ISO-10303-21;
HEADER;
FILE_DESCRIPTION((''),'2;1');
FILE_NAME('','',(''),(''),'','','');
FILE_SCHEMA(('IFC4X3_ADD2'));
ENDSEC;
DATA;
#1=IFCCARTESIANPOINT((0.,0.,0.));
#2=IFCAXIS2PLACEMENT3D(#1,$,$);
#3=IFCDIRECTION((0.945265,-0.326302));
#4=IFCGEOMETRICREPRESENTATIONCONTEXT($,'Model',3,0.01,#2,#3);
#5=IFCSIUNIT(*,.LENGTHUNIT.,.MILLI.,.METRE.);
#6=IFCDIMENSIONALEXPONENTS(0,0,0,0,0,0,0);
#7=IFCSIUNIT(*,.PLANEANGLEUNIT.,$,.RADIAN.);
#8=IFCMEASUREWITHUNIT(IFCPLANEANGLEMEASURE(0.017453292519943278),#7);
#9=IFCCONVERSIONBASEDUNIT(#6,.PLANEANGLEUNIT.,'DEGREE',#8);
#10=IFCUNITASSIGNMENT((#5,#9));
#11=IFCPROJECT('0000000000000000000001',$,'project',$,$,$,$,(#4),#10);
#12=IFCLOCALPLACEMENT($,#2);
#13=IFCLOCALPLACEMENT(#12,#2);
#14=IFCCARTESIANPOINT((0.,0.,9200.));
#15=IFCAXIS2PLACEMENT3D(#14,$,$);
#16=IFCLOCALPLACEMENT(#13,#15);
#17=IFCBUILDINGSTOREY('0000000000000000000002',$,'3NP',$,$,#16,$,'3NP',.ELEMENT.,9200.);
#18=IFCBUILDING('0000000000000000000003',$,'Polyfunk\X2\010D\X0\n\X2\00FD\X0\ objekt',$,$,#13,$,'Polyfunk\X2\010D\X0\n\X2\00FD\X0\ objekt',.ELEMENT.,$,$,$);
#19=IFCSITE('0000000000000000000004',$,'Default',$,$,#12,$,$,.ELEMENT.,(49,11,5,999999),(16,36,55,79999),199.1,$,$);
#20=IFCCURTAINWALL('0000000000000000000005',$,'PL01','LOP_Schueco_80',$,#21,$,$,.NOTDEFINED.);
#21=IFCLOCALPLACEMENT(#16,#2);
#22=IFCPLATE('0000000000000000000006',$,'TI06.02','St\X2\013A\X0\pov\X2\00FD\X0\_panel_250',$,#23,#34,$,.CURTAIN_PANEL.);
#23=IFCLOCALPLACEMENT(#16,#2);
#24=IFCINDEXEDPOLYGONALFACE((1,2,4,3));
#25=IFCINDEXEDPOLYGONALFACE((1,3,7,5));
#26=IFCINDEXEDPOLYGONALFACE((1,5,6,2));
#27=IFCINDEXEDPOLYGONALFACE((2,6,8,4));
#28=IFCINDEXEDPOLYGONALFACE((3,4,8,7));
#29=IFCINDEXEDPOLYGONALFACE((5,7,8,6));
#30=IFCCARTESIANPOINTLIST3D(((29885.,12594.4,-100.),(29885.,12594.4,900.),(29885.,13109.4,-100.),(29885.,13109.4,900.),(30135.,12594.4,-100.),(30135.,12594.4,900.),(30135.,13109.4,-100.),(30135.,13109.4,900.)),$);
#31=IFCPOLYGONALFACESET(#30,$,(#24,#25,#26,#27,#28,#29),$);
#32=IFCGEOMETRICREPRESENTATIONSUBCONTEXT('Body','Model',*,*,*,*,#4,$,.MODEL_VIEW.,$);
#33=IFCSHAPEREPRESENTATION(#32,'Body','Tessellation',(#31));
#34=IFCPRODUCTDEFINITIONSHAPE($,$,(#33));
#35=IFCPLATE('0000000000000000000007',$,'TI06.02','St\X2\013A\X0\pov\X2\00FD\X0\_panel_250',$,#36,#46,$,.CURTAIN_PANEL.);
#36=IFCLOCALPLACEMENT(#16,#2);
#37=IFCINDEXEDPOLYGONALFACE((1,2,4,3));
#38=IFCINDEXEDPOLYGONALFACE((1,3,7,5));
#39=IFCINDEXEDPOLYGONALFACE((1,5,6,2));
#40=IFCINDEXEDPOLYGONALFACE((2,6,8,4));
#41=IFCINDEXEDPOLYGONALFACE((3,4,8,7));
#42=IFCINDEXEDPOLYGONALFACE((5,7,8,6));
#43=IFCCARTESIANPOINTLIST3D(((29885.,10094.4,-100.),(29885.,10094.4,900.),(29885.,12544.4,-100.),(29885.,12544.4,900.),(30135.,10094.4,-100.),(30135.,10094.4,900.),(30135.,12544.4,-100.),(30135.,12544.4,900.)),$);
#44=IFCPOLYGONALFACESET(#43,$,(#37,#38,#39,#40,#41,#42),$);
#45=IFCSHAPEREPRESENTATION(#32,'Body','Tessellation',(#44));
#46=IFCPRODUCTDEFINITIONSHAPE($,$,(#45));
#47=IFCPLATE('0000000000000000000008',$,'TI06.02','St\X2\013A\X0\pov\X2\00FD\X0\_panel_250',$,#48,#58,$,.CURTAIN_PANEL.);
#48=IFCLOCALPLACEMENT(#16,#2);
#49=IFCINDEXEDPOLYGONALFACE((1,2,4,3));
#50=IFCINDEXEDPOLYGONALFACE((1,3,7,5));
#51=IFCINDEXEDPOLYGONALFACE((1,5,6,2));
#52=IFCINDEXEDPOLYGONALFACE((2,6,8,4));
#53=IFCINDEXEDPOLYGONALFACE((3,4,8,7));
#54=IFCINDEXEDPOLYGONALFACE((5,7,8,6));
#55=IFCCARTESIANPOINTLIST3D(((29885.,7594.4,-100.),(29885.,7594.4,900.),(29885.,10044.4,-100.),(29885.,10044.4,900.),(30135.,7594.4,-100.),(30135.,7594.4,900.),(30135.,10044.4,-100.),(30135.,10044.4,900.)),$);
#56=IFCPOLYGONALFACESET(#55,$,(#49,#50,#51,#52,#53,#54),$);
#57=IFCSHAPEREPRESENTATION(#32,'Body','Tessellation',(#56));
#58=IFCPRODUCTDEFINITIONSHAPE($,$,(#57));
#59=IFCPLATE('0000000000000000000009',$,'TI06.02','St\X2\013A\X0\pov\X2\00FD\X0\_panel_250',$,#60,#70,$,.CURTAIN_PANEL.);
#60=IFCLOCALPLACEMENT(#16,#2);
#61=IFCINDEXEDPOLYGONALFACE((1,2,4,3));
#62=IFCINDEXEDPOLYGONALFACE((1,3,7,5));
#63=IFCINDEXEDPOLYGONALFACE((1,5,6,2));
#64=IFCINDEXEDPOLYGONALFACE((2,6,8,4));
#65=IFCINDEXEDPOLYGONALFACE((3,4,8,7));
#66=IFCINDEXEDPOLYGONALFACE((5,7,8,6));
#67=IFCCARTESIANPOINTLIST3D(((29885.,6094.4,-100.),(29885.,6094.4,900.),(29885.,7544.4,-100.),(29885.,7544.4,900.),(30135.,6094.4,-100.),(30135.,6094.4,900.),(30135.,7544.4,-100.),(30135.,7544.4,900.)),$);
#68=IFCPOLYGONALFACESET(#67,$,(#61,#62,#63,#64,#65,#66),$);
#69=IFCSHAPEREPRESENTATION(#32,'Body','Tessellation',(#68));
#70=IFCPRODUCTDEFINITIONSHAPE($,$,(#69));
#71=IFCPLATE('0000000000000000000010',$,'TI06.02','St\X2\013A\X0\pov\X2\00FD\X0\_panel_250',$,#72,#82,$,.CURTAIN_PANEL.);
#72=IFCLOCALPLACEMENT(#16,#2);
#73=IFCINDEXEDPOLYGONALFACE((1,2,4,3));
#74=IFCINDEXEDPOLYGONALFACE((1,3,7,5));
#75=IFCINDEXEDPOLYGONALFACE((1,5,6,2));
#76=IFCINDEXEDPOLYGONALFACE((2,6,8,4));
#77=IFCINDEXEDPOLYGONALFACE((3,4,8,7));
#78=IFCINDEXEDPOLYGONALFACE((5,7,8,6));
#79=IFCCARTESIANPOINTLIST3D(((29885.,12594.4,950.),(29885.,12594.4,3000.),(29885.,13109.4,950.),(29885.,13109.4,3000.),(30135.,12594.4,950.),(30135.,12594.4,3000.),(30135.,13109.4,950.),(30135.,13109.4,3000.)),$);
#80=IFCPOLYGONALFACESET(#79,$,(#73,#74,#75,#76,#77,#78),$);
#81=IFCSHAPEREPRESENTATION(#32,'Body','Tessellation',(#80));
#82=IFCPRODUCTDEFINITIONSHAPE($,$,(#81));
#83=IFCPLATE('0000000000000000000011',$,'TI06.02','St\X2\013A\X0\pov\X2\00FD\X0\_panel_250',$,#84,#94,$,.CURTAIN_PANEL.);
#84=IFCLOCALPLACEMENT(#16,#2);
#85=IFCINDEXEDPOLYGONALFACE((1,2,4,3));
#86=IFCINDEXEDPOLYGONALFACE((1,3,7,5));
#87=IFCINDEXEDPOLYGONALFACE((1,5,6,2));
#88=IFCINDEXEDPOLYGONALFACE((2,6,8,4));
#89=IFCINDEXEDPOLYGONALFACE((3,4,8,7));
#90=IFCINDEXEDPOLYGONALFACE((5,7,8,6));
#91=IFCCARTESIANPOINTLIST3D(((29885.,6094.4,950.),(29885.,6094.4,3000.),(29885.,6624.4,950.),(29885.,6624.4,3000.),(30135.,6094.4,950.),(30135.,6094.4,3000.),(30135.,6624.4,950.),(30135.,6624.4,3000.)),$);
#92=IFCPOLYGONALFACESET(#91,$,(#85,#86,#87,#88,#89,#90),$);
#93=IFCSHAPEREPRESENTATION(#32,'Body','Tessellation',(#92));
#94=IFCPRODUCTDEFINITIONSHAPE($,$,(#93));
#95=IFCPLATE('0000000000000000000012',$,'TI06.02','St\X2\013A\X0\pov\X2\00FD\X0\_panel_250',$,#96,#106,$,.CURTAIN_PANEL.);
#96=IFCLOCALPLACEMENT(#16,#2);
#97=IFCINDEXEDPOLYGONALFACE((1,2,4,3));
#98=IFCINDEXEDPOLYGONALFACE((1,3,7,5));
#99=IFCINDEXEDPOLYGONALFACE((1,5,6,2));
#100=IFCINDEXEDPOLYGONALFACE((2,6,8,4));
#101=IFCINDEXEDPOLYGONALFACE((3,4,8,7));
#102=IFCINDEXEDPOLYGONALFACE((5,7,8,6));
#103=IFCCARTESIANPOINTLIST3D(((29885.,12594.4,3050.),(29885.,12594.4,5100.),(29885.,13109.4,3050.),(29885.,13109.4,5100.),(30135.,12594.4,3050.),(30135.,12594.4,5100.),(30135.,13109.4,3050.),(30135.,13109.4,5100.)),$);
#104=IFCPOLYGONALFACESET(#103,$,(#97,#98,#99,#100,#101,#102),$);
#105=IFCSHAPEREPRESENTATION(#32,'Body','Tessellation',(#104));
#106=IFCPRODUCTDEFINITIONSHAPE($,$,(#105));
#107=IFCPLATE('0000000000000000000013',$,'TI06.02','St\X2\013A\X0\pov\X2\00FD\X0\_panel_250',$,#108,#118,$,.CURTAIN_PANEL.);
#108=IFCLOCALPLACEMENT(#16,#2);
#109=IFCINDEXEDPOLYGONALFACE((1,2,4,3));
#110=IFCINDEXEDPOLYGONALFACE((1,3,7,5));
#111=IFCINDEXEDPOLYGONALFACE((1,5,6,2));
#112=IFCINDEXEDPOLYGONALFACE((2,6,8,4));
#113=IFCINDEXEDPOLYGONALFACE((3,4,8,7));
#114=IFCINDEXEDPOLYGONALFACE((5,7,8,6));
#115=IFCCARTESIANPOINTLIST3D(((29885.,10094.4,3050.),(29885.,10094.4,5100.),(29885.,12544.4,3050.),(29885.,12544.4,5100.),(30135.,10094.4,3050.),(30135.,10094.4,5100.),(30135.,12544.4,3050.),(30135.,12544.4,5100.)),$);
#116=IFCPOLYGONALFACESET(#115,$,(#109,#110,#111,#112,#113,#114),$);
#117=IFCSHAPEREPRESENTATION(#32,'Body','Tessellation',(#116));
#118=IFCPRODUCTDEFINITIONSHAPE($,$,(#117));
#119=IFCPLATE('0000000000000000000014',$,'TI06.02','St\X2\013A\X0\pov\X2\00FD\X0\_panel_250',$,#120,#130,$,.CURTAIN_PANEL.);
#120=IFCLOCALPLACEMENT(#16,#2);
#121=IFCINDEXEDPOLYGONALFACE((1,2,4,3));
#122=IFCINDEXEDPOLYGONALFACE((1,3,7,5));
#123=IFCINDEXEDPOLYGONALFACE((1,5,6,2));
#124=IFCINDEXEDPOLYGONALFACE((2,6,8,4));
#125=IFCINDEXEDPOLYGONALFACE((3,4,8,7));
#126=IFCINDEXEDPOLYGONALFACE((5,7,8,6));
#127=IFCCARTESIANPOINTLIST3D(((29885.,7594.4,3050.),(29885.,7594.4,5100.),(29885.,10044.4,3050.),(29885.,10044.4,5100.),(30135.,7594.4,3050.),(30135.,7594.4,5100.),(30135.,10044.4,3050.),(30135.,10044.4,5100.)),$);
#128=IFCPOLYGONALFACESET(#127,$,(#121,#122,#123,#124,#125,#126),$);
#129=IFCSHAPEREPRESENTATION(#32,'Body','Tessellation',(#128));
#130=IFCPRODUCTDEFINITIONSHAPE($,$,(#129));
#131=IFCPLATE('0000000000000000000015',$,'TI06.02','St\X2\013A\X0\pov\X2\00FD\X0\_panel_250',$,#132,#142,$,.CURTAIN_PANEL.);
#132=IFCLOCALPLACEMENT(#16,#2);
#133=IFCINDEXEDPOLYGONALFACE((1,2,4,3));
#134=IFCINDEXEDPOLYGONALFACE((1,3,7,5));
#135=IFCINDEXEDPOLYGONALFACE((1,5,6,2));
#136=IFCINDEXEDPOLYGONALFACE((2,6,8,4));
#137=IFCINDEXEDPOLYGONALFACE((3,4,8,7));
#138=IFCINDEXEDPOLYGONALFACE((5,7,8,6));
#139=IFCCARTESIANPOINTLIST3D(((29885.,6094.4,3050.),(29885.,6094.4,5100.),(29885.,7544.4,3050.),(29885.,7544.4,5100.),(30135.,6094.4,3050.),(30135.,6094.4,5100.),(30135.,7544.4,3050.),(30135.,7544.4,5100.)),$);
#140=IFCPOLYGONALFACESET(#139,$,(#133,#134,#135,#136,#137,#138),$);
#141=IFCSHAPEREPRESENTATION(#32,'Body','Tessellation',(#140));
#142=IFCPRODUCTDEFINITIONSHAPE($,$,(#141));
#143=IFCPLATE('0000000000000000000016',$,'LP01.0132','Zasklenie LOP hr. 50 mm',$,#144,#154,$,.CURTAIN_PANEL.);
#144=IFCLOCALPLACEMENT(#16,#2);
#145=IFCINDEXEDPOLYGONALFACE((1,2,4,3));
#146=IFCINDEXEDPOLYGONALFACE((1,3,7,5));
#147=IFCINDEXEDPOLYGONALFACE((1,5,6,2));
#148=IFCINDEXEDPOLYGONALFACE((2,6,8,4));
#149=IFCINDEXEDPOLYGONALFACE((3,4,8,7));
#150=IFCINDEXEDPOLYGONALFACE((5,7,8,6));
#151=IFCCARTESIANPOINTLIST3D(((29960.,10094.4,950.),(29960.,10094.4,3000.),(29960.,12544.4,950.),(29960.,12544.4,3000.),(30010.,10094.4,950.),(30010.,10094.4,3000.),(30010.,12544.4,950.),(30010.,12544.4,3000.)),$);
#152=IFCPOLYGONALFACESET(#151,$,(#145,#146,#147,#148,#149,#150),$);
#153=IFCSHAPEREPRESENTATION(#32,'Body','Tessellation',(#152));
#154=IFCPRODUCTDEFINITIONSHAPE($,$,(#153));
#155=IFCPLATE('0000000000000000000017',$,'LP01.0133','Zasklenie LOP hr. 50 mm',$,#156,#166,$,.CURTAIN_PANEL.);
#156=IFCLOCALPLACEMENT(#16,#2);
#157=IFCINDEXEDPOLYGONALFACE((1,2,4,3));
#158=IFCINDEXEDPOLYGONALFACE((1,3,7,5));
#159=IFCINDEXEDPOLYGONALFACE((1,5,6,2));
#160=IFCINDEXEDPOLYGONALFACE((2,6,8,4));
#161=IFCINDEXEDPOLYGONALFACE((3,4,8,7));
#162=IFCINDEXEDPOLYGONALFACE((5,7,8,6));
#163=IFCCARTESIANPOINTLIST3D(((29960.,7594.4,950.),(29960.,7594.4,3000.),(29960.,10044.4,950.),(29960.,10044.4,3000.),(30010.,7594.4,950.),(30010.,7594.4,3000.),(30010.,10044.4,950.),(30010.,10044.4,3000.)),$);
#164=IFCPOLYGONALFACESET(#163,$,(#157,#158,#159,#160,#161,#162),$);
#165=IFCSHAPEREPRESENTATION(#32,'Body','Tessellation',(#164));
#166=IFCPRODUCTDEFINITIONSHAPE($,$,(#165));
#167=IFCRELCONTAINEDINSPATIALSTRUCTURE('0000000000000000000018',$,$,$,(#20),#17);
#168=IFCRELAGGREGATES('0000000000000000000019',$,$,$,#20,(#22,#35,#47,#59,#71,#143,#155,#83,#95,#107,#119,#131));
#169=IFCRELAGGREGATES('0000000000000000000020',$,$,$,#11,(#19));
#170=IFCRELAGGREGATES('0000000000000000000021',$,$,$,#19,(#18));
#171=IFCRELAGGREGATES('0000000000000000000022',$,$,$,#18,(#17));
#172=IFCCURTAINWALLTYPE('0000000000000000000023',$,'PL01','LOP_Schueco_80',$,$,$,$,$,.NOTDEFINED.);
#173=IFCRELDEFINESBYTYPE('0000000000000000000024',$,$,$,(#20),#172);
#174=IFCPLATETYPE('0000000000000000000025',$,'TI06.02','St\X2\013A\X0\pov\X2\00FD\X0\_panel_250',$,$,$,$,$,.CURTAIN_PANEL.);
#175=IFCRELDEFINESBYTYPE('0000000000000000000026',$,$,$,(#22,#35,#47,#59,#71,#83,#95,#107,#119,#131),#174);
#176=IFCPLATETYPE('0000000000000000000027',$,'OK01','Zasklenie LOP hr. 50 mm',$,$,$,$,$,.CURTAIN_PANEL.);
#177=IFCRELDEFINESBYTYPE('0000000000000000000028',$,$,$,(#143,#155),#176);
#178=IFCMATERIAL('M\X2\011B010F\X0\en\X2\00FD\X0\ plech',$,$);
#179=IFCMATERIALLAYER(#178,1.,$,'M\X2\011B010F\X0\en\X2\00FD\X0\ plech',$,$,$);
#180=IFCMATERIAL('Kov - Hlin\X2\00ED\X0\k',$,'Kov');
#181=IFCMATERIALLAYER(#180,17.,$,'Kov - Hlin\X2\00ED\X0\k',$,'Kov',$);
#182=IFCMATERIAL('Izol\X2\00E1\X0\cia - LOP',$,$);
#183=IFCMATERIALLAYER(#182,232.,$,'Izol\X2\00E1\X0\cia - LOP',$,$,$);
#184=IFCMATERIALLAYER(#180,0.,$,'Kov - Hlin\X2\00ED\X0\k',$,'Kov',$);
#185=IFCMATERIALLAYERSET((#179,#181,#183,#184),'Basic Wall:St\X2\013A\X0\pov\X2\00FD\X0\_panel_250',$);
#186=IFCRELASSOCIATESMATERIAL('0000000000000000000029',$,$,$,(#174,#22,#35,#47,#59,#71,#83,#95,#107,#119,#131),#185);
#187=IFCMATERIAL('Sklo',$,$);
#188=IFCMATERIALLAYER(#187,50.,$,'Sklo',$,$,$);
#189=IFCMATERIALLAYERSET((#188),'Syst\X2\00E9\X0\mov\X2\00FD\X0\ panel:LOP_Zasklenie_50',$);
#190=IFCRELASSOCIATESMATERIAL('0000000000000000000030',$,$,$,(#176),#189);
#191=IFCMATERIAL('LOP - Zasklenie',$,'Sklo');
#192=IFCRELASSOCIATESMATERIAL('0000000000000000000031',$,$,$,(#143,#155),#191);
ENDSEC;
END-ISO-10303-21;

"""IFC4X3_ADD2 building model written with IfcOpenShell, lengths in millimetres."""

from ifc_helpers import new_model, entity, si_unit, converted_unit, direction, frame, frame_2d, origin, origin_2d_with_axis, place, context, subcontext, project, spatial, rectangle, extrude, source, transform, mapped, material, layer, layer_set, layer_usage, type_object, type_shapes, element, aggregate, save


model = new_model("IFC4X3_ADD2")

# Units and contexts
model_context = context("Model", 3, precision=0.01, world=origin(), true_north=direction((0.945265, -0.326302)))
body_context = subcontext(model_context, "Body", "Model", "MODEL_VIEW")
ifc_project = project(units=[si_unit("LENGTHUNIT", "METRE", prefix="MILLI"), converted_unit("PLANEANGLEUNIT", "DEGREE", entity("IfcPlaneAngleMeasure", 0.017453292519943278), si_unit("PLANEANGLEUNIT", "RADIAN"), dimensions=[0, 0, 0, 0, 0, 0, 0])], contexts=[model_context])

# Site, building, storey
site_placement = place(None, origin())
site = spatial("IfcSite", under=ifc_project, at=site_placement, Name="Default", CompositionType="ELEMENT", RefLatitude=(49, 11, 5, 999999), RefLongitude=(16, 36, 55, 79999), RefElevation=199.1)
building_placement = place(site_placement, origin())
building = spatial("IfcBuilding", under=site, at=building_placement, Name="Polyfunkčný objekt", LongName="Polyfunkčný objekt", CompositionType="ELEMENT")
storey_placement = place(building_placement, frame((0.0, 0.0, 9200.0)))
storey = spatial("IfcBuildingStorey", under=building, at=storey_placement, Name="3NP", LongName="3NP", CompositionType="ELEMENT", Elevation=9200.0)

# Shared definitions
curtain_wall_type = type_object("IfcCurtainWallType", Name="PL01", Description="LOP_Schueco_80", PredefinedType="NOTDEFINED")

# Curtain wall, plates
curtain_wall_1_placement = place(storey_placement, frame((0.0, 0.0, -9200.0)))
curtain_wall_1 = element("IfcCurtainWall", 1, at=curtain_wall_1_placement, inside=storey, type_object=curtain_wall_type, Name="PL01", Description="LOP_Schueco_80", PredefinedType="NOTDEFINED")
ifc_material_1 = material(Name="Měďený plech")
ifc_layer_1 = layer(ifc_material_1, 1.0, Name="Měďený plech")
ifc_material_2 = material(Name="Kov - Hliník", Category="Kov")
ifc_layer_2 = layer(ifc_material_2, 17.0, Name="Kov - Hliník", Category="Kov")
ifc_material_3 = material(Name="Izolácia - LOP")
ifc_layer_3 = layer(ifc_material_3, 232.0, Name="Izolácia - LOP")
ifc_layer_4 = layer(ifc_material_2, 0.0, Name="Kov - Hliník", Category="Kov")
ifc_layer_set_1 = layer_set([ifc_layer_1, ifc_layer_2, ifc_layer_3, ifc_layer_4], Name="Basic Wall:Stĺpový_panel_250")
ifc_layer_usage_1 = layer_usage(ifc_layer_set_1, "AXIS2", "POSITIVE", -125.0)
plate_type_1 = type_object("IfcPlateType", Name="TI06.02", Description="Stĺpový_panel_250", PredefinedType="CURTAIN_PANEL", material=ifc_layer_set_1)
plate_1_placement = place(storey_placement, frame((30010.0, 13109.4, -100.0), z_axis=(0.0, 0.0, 1.0), x_axis=(0.0, -1.0, 0.0)))
plate_1 = element("IfcPlate", 2, at=plate_1_placement, type_object=plate_type_1, material=ifc_layer_usage_1, Name="TI06.02", Description="Stĺpový_panel_250", PredefinedType="CURTAIN_PANEL", context=body_context, shape_type="SweptSolid", body=[
    extrude(rectangle(XDim=250.0, YDim=515.0, at=frame_2d((0.0, 0.0), x_axis=(1.0, 0.0))), frame((257.5, 0.0, 0.0), z_axis=(0.0, 0.0, 1.0), x_axis=(0.0, 1.0, 0.0)), (0.0, 0.0, 1.0), 1000.0),
])
ifc_layer_usage_2 = layer_usage(ifc_layer_set_1, "AXIS2", "POSITIVE", -125.0)
plate_2_placement = place(storey_placement, frame((30010.0, 12544.4, -100.0), z_axis=(0.0, 0.0, 1.0), x_axis=(0.0, -1.0, 0.0)))
plate_2 = element("IfcPlate", 3, at=plate_2_placement, type_object=plate_type_1, material=ifc_layer_usage_2, Name="TI06.02", Description="Stĺpový_panel_250", PredefinedType="CURTAIN_PANEL", context=body_context, shape_type="SweptSolid", body=[
    extrude(rectangle(XDim=250.0, YDim=2450.0, at=frame_2d((0.0, 0.0), x_axis=(1.0, 0.0))), frame((1225.0, 0.0, 0.0), z_axis=(0.0, 0.0, 1.0), x_axis=(0.0, 1.0, 0.0)), (0.0, 0.0, 1.0), 1000.0),
])
ifc_layer_usage_3 = layer_usage(ifc_layer_set_1, "AXIS2", "POSITIVE", -125.0)
plate_3_placement = place(storey_placement, frame((30010.0, 10044.4, -100.0), z_axis=(0.0, 0.0, 1.0), x_axis=(0.0, -1.0, 0.0)))
plate_3 = element("IfcPlate", 4, at=plate_3_placement, type_object=plate_type_1, material=ifc_layer_usage_3, Name="TI06.02", Description="Stĺpový_panel_250", PredefinedType="CURTAIN_PANEL", context=body_context, shape_type="SweptSolid", body=[
    extrude(rectangle(XDim=250.0, YDim=2450.0, at=origin_2d_with_axis()), frame((1225.0, 0.0, 0.0), z_axis=(0.0, 0.0, 1.0), x_axis=(0.0, 1.0, 0.0)), (0.0, 0.0, 1.0), 1000.0),
])
ifc_layer_usage_4 = layer_usage(ifc_layer_set_1, "AXIS2", "POSITIVE", -125.0)
plate_4_placement = place(storey_placement, frame((30010.0, 7544.4, -100.0), z_axis=(0.0, 0.0, 1.0), x_axis=(0.0, -1.0, 0.0)))
plate_4 = element("IfcPlate", 5, at=plate_4_placement, type_object=plate_type_1, material=ifc_layer_usage_4, Name="TI06.02", Description="Stĺpový_panel_250", PredefinedType="CURTAIN_PANEL", context=body_context, shape_type="SweptSolid", body=[
    extrude(rectangle(XDim=250.0, YDim=1450.0, at=frame_2d((0.0, 0.0), x_axis=(1.0, 0.0))), frame((725.0, 0.0, 0.0), z_axis=(0.0, 0.0, 1.0), x_axis=(0.0, 1.0, 0.0)), (0.0, 0.0, 1.0), 1000.0),
])
ifc_layer_usage_5 = layer_usage(ifc_layer_set_1, "AXIS2", "POSITIVE", -125.0)
plate_5_placement = place(storey_placement, frame((30010.0, 13109.4, 950.0), z_axis=(0.0, 0.0, 1.0), x_axis=(0.0, -1.0, 0.0)))
plate_5 = element("IfcPlate", 6, at=plate_5_placement, type_object=plate_type_1, material=ifc_layer_usage_5, Name="TI06.02", Description="Stĺpový_panel_250", PredefinedType="CURTAIN_PANEL", context=body_context, shape_type="SweptSolid", body=[
    extrude(rectangle(XDim=250.0, YDim=515.0, at=frame_2d((0.0, 0.0), x_axis=(1.0, 0.0))), frame((257.5, 0.0, 0.0), z_axis=(0.0, 0.0, 1.0), x_axis=(0.0, 1.0, 0.0)), (0.0, 0.0, 1.0), 2050.0),
])
ifc_layer_usage_6 = layer_usage(ifc_layer_set_1, "AXIS2", "POSITIVE", -125.0)
plate_6_placement = place(storey_placement, frame((30010.0, 6624.4, 950.0), z_axis=(0.0, 0.0, 1.0), x_axis=(0.0, -1.0, 0.0)))
plate_6 = element("IfcPlate", 7, at=plate_6_placement, type_object=plate_type_1, material=ifc_layer_usage_6, Name="TI06.02", Description="Stĺpový_panel_250", PredefinedType="CURTAIN_PANEL", context=body_context, shape_type="SweptSolid", body=[
    extrude(rectangle(XDim=250.0, YDim=530.0, at=frame_2d((0.0, 0.0), x_axis=(1.0, 0.0))), frame((265.0, 0.0, 0.0), z_axis=(0.0, 0.0, 1.0), x_axis=(0.0, 1.0, 0.0)), (0.0, 0.0, 1.0), 2050.0),
])
ifc_layer_usage_7 = layer_usage(ifc_layer_set_1, "AXIS2", "POSITIVE", -125.0)
plate_7_placement = place(storey_placement, frame((30010.0, 13109.4, 3050.0), z_axis=(0.0, 0.0, 1.0), x_axis=(0.0, -1.0, 0.0)))
plate_7 = element("IfcPlate", 8, at=plate_7_placement, type_object=plate_type_1, material=ifc_layer_usage_7, Name="TI06.02", Description="Stĺpový_panel_250", PredefinedType="CURTAIN_PANEL", context=body_context, shape_type="SweptSolid", body=[
    extrude(rectangle(XDim=250.0, YDim=515.0, at=frame_2d((0.0, 0.0), x_axis=(1.0, 0.0))), frame((257.5, 0.0, 0.0), z_axis=(0.0, 0.0, 1.0), x_axis=(0.0, 1.0, 0.0)), (0.0, 0.0, 1.0), 2050.0),
])
ifc_layer_usage_8 = layer_usage(ifc_layer_set_1, "AXIS2", "POSITIVE", -125.0)
plate_8_placement = place(storey_placement, frame((30010.0, 12544.4, 3050.0), z_axis=(0.0, 0.0, 1.0), x_axis=(0.0, -1.0, 0.0)))
plate_8 = element("IfcPlate", 9, at=plate_8_placement, type_object=plate_type_1, material=ifc_layer_usage_8, Name="TI06.02", Description="Stĺpový_panel_250", PredefinedType="CURTAIN_PANEL", context=body_context, shape_type="SweptSolid", body=[
    extrude(rectangle(XDim=250.0, YDim=2450.0, at=frame_2d((0.0, 0.0), x_axis=(1.0, 0.0))), frame((1225.0, 0.0, 0.0), z_axis=(0.0, 0.0, 1.0), x_axis=(0.0, 1.0, 0.0)), (0.0, 0.0, 1.0), 2050.0),
])
ifc_layer_usage_9 = layer_usage(ifc_layer_set_1, "AXIS2", "POSITIVE", -125.0)
plate_9_placement = place(storey_placement, frame((30010.0, 10044.4, 3050.0), z_axis=(0.0, 0.0, 1.0), x_axis=(0.0, -1.0, 0.0)))
plate_9 = element("IfcPlate", 10, at=plate_9_placement, type_object=plate_type_1, material=ifc_layer_usage_9, Name="TI06.02", Description="Stĺpový_panel_250", PredefinedType="CURTAIN_PANEL", context=body_context, shape_type="SweptSolid", body=[
    extrude(rectangle(XDim=250.0, YDim=2450.0, at=frame_2d((0.0, 0.0), x_axis=(1.0, 0.0))), frame((1225.0, 0.0, 0.0), z_axis=(0.0, 0.0, 1.0), x_axis=(0.0, 1.0, 0.0)), (0.0, 0.0, 1.0), 2050.0),
])
ifc_layer_usage_10 = layer_usage(ifc_layer_set_1, "AXIS2", "POSITIVE", -125.0)
plate_10_placement = place(storey_placement, frame((30010.0, 7544.4, 3050.0), z_axis=(0.0, 0.0, 1.0), x_axis=(0.0, -1.0, 0.0)))
plate_10 = element("IfcPlate", 11, at=plate_10_placement, type_object=plate_type_1, material=ifc_layer_usage_10, Name="TI06.02", Description="Stĺpový_panel_250", PredefinedType="CURTAIN_PANEL", context=body_context, shape_type="SweptSolid", body=[
    extrude(rectangle(XDim=250.0, YDim=1450.0, at=frame_2d((0.0, 0.0), x_axis=(1.0, 0.0))), frame((725.0, 0.0, 0.0), z_axis=(0.0, 0.0, 1.0), x_axis=(0.0, 1.0, 0.0)), (0.0, 0.0, 1.0), 2050.0),
])
ifc_material_4 = material(Name="LOP - Zasklenie", Category="Sklo")
ifc_material_5 = material(Name="Sklo")
ifc_layer_5 = layer(ifc_material_5, 50.0, Name="Sklo")
ifc_layer_set_2 = layer_set([ifc_layer_5], Name="Systémový panel:LOP_Zasklenie_50")
plate_type_2 = type_object("IfcPlateType", Name="OK01", Description="Zasklenie LOP hr. 50 mm", PredefinedType="CURTAIN_PANEL", material=ifc_layer_set_2)
shared_shape_1 = source(origin(), body_context, "Body", "SweptSolid", [
    extrude(rectangle(XDim=50.0, YDim=2450.0, at=origin_2d_with_axis()), frame((0.0, -25.0, 0.0), z_axis=(0.0, 0.0, 1.0), x_axis=(0.0, 1.0, 0.0)), (0.0, 0.0, 1.0), 2050.0),
])
type_shapes(plate_type_2, [shared_shape_1])
plate_11_placement = place(curtain_wall_1_placement, frame((30010.0, 11319.4, 10150.0), z_axis=(0.0, 0.0, 1.0), x_axis=(0.0, -1.0, 0.0)))
plate_11 = element("IfcPlate", 12, at=plate_11_placement, type_object=plate_type_2, material=ifc_material_4, Name="LP01.0132", Description="Zasklenie LOP hr. 50 mm", PredefinedType="CURTAIN_PANEL", context=body_context, shape_type="MappedRepresentation", body=[
    mapped(shared_shape_1, transform((0.0, 0.0, 0.0), scale=1.0)),
])
plate_12_placement = place(curtain_wall_1_placement, frame((30010.0, 8819.4, 10150.0), z_axis=(0.0, 0.0, 1.0), x_axis=(0.0, -1.0, 0.0)))
plate_12 = element("IfcPlate", 13, at=plate_12_placement, type_object=plate_type_2, material=ifc_material_4, Name="LP01.0133", Description="Zasklenie LOP hr. 50 mm", PredefinedType="CURTAIN_PANEL", context=body_context, shape_type="MappedRepresentation", body=[
    mapped(shared_shape_1, transform((0.0, 0.0, 0.0), scale=1.0)),
])
aggregate(curtain_wall_1, [plate_1, plate_2, plate_3, plate_4, plate_5, plate_11, plate_12, plate_6, plate_7, plate_8, plate_9, plate_10])

save(model, "model.ifc")
